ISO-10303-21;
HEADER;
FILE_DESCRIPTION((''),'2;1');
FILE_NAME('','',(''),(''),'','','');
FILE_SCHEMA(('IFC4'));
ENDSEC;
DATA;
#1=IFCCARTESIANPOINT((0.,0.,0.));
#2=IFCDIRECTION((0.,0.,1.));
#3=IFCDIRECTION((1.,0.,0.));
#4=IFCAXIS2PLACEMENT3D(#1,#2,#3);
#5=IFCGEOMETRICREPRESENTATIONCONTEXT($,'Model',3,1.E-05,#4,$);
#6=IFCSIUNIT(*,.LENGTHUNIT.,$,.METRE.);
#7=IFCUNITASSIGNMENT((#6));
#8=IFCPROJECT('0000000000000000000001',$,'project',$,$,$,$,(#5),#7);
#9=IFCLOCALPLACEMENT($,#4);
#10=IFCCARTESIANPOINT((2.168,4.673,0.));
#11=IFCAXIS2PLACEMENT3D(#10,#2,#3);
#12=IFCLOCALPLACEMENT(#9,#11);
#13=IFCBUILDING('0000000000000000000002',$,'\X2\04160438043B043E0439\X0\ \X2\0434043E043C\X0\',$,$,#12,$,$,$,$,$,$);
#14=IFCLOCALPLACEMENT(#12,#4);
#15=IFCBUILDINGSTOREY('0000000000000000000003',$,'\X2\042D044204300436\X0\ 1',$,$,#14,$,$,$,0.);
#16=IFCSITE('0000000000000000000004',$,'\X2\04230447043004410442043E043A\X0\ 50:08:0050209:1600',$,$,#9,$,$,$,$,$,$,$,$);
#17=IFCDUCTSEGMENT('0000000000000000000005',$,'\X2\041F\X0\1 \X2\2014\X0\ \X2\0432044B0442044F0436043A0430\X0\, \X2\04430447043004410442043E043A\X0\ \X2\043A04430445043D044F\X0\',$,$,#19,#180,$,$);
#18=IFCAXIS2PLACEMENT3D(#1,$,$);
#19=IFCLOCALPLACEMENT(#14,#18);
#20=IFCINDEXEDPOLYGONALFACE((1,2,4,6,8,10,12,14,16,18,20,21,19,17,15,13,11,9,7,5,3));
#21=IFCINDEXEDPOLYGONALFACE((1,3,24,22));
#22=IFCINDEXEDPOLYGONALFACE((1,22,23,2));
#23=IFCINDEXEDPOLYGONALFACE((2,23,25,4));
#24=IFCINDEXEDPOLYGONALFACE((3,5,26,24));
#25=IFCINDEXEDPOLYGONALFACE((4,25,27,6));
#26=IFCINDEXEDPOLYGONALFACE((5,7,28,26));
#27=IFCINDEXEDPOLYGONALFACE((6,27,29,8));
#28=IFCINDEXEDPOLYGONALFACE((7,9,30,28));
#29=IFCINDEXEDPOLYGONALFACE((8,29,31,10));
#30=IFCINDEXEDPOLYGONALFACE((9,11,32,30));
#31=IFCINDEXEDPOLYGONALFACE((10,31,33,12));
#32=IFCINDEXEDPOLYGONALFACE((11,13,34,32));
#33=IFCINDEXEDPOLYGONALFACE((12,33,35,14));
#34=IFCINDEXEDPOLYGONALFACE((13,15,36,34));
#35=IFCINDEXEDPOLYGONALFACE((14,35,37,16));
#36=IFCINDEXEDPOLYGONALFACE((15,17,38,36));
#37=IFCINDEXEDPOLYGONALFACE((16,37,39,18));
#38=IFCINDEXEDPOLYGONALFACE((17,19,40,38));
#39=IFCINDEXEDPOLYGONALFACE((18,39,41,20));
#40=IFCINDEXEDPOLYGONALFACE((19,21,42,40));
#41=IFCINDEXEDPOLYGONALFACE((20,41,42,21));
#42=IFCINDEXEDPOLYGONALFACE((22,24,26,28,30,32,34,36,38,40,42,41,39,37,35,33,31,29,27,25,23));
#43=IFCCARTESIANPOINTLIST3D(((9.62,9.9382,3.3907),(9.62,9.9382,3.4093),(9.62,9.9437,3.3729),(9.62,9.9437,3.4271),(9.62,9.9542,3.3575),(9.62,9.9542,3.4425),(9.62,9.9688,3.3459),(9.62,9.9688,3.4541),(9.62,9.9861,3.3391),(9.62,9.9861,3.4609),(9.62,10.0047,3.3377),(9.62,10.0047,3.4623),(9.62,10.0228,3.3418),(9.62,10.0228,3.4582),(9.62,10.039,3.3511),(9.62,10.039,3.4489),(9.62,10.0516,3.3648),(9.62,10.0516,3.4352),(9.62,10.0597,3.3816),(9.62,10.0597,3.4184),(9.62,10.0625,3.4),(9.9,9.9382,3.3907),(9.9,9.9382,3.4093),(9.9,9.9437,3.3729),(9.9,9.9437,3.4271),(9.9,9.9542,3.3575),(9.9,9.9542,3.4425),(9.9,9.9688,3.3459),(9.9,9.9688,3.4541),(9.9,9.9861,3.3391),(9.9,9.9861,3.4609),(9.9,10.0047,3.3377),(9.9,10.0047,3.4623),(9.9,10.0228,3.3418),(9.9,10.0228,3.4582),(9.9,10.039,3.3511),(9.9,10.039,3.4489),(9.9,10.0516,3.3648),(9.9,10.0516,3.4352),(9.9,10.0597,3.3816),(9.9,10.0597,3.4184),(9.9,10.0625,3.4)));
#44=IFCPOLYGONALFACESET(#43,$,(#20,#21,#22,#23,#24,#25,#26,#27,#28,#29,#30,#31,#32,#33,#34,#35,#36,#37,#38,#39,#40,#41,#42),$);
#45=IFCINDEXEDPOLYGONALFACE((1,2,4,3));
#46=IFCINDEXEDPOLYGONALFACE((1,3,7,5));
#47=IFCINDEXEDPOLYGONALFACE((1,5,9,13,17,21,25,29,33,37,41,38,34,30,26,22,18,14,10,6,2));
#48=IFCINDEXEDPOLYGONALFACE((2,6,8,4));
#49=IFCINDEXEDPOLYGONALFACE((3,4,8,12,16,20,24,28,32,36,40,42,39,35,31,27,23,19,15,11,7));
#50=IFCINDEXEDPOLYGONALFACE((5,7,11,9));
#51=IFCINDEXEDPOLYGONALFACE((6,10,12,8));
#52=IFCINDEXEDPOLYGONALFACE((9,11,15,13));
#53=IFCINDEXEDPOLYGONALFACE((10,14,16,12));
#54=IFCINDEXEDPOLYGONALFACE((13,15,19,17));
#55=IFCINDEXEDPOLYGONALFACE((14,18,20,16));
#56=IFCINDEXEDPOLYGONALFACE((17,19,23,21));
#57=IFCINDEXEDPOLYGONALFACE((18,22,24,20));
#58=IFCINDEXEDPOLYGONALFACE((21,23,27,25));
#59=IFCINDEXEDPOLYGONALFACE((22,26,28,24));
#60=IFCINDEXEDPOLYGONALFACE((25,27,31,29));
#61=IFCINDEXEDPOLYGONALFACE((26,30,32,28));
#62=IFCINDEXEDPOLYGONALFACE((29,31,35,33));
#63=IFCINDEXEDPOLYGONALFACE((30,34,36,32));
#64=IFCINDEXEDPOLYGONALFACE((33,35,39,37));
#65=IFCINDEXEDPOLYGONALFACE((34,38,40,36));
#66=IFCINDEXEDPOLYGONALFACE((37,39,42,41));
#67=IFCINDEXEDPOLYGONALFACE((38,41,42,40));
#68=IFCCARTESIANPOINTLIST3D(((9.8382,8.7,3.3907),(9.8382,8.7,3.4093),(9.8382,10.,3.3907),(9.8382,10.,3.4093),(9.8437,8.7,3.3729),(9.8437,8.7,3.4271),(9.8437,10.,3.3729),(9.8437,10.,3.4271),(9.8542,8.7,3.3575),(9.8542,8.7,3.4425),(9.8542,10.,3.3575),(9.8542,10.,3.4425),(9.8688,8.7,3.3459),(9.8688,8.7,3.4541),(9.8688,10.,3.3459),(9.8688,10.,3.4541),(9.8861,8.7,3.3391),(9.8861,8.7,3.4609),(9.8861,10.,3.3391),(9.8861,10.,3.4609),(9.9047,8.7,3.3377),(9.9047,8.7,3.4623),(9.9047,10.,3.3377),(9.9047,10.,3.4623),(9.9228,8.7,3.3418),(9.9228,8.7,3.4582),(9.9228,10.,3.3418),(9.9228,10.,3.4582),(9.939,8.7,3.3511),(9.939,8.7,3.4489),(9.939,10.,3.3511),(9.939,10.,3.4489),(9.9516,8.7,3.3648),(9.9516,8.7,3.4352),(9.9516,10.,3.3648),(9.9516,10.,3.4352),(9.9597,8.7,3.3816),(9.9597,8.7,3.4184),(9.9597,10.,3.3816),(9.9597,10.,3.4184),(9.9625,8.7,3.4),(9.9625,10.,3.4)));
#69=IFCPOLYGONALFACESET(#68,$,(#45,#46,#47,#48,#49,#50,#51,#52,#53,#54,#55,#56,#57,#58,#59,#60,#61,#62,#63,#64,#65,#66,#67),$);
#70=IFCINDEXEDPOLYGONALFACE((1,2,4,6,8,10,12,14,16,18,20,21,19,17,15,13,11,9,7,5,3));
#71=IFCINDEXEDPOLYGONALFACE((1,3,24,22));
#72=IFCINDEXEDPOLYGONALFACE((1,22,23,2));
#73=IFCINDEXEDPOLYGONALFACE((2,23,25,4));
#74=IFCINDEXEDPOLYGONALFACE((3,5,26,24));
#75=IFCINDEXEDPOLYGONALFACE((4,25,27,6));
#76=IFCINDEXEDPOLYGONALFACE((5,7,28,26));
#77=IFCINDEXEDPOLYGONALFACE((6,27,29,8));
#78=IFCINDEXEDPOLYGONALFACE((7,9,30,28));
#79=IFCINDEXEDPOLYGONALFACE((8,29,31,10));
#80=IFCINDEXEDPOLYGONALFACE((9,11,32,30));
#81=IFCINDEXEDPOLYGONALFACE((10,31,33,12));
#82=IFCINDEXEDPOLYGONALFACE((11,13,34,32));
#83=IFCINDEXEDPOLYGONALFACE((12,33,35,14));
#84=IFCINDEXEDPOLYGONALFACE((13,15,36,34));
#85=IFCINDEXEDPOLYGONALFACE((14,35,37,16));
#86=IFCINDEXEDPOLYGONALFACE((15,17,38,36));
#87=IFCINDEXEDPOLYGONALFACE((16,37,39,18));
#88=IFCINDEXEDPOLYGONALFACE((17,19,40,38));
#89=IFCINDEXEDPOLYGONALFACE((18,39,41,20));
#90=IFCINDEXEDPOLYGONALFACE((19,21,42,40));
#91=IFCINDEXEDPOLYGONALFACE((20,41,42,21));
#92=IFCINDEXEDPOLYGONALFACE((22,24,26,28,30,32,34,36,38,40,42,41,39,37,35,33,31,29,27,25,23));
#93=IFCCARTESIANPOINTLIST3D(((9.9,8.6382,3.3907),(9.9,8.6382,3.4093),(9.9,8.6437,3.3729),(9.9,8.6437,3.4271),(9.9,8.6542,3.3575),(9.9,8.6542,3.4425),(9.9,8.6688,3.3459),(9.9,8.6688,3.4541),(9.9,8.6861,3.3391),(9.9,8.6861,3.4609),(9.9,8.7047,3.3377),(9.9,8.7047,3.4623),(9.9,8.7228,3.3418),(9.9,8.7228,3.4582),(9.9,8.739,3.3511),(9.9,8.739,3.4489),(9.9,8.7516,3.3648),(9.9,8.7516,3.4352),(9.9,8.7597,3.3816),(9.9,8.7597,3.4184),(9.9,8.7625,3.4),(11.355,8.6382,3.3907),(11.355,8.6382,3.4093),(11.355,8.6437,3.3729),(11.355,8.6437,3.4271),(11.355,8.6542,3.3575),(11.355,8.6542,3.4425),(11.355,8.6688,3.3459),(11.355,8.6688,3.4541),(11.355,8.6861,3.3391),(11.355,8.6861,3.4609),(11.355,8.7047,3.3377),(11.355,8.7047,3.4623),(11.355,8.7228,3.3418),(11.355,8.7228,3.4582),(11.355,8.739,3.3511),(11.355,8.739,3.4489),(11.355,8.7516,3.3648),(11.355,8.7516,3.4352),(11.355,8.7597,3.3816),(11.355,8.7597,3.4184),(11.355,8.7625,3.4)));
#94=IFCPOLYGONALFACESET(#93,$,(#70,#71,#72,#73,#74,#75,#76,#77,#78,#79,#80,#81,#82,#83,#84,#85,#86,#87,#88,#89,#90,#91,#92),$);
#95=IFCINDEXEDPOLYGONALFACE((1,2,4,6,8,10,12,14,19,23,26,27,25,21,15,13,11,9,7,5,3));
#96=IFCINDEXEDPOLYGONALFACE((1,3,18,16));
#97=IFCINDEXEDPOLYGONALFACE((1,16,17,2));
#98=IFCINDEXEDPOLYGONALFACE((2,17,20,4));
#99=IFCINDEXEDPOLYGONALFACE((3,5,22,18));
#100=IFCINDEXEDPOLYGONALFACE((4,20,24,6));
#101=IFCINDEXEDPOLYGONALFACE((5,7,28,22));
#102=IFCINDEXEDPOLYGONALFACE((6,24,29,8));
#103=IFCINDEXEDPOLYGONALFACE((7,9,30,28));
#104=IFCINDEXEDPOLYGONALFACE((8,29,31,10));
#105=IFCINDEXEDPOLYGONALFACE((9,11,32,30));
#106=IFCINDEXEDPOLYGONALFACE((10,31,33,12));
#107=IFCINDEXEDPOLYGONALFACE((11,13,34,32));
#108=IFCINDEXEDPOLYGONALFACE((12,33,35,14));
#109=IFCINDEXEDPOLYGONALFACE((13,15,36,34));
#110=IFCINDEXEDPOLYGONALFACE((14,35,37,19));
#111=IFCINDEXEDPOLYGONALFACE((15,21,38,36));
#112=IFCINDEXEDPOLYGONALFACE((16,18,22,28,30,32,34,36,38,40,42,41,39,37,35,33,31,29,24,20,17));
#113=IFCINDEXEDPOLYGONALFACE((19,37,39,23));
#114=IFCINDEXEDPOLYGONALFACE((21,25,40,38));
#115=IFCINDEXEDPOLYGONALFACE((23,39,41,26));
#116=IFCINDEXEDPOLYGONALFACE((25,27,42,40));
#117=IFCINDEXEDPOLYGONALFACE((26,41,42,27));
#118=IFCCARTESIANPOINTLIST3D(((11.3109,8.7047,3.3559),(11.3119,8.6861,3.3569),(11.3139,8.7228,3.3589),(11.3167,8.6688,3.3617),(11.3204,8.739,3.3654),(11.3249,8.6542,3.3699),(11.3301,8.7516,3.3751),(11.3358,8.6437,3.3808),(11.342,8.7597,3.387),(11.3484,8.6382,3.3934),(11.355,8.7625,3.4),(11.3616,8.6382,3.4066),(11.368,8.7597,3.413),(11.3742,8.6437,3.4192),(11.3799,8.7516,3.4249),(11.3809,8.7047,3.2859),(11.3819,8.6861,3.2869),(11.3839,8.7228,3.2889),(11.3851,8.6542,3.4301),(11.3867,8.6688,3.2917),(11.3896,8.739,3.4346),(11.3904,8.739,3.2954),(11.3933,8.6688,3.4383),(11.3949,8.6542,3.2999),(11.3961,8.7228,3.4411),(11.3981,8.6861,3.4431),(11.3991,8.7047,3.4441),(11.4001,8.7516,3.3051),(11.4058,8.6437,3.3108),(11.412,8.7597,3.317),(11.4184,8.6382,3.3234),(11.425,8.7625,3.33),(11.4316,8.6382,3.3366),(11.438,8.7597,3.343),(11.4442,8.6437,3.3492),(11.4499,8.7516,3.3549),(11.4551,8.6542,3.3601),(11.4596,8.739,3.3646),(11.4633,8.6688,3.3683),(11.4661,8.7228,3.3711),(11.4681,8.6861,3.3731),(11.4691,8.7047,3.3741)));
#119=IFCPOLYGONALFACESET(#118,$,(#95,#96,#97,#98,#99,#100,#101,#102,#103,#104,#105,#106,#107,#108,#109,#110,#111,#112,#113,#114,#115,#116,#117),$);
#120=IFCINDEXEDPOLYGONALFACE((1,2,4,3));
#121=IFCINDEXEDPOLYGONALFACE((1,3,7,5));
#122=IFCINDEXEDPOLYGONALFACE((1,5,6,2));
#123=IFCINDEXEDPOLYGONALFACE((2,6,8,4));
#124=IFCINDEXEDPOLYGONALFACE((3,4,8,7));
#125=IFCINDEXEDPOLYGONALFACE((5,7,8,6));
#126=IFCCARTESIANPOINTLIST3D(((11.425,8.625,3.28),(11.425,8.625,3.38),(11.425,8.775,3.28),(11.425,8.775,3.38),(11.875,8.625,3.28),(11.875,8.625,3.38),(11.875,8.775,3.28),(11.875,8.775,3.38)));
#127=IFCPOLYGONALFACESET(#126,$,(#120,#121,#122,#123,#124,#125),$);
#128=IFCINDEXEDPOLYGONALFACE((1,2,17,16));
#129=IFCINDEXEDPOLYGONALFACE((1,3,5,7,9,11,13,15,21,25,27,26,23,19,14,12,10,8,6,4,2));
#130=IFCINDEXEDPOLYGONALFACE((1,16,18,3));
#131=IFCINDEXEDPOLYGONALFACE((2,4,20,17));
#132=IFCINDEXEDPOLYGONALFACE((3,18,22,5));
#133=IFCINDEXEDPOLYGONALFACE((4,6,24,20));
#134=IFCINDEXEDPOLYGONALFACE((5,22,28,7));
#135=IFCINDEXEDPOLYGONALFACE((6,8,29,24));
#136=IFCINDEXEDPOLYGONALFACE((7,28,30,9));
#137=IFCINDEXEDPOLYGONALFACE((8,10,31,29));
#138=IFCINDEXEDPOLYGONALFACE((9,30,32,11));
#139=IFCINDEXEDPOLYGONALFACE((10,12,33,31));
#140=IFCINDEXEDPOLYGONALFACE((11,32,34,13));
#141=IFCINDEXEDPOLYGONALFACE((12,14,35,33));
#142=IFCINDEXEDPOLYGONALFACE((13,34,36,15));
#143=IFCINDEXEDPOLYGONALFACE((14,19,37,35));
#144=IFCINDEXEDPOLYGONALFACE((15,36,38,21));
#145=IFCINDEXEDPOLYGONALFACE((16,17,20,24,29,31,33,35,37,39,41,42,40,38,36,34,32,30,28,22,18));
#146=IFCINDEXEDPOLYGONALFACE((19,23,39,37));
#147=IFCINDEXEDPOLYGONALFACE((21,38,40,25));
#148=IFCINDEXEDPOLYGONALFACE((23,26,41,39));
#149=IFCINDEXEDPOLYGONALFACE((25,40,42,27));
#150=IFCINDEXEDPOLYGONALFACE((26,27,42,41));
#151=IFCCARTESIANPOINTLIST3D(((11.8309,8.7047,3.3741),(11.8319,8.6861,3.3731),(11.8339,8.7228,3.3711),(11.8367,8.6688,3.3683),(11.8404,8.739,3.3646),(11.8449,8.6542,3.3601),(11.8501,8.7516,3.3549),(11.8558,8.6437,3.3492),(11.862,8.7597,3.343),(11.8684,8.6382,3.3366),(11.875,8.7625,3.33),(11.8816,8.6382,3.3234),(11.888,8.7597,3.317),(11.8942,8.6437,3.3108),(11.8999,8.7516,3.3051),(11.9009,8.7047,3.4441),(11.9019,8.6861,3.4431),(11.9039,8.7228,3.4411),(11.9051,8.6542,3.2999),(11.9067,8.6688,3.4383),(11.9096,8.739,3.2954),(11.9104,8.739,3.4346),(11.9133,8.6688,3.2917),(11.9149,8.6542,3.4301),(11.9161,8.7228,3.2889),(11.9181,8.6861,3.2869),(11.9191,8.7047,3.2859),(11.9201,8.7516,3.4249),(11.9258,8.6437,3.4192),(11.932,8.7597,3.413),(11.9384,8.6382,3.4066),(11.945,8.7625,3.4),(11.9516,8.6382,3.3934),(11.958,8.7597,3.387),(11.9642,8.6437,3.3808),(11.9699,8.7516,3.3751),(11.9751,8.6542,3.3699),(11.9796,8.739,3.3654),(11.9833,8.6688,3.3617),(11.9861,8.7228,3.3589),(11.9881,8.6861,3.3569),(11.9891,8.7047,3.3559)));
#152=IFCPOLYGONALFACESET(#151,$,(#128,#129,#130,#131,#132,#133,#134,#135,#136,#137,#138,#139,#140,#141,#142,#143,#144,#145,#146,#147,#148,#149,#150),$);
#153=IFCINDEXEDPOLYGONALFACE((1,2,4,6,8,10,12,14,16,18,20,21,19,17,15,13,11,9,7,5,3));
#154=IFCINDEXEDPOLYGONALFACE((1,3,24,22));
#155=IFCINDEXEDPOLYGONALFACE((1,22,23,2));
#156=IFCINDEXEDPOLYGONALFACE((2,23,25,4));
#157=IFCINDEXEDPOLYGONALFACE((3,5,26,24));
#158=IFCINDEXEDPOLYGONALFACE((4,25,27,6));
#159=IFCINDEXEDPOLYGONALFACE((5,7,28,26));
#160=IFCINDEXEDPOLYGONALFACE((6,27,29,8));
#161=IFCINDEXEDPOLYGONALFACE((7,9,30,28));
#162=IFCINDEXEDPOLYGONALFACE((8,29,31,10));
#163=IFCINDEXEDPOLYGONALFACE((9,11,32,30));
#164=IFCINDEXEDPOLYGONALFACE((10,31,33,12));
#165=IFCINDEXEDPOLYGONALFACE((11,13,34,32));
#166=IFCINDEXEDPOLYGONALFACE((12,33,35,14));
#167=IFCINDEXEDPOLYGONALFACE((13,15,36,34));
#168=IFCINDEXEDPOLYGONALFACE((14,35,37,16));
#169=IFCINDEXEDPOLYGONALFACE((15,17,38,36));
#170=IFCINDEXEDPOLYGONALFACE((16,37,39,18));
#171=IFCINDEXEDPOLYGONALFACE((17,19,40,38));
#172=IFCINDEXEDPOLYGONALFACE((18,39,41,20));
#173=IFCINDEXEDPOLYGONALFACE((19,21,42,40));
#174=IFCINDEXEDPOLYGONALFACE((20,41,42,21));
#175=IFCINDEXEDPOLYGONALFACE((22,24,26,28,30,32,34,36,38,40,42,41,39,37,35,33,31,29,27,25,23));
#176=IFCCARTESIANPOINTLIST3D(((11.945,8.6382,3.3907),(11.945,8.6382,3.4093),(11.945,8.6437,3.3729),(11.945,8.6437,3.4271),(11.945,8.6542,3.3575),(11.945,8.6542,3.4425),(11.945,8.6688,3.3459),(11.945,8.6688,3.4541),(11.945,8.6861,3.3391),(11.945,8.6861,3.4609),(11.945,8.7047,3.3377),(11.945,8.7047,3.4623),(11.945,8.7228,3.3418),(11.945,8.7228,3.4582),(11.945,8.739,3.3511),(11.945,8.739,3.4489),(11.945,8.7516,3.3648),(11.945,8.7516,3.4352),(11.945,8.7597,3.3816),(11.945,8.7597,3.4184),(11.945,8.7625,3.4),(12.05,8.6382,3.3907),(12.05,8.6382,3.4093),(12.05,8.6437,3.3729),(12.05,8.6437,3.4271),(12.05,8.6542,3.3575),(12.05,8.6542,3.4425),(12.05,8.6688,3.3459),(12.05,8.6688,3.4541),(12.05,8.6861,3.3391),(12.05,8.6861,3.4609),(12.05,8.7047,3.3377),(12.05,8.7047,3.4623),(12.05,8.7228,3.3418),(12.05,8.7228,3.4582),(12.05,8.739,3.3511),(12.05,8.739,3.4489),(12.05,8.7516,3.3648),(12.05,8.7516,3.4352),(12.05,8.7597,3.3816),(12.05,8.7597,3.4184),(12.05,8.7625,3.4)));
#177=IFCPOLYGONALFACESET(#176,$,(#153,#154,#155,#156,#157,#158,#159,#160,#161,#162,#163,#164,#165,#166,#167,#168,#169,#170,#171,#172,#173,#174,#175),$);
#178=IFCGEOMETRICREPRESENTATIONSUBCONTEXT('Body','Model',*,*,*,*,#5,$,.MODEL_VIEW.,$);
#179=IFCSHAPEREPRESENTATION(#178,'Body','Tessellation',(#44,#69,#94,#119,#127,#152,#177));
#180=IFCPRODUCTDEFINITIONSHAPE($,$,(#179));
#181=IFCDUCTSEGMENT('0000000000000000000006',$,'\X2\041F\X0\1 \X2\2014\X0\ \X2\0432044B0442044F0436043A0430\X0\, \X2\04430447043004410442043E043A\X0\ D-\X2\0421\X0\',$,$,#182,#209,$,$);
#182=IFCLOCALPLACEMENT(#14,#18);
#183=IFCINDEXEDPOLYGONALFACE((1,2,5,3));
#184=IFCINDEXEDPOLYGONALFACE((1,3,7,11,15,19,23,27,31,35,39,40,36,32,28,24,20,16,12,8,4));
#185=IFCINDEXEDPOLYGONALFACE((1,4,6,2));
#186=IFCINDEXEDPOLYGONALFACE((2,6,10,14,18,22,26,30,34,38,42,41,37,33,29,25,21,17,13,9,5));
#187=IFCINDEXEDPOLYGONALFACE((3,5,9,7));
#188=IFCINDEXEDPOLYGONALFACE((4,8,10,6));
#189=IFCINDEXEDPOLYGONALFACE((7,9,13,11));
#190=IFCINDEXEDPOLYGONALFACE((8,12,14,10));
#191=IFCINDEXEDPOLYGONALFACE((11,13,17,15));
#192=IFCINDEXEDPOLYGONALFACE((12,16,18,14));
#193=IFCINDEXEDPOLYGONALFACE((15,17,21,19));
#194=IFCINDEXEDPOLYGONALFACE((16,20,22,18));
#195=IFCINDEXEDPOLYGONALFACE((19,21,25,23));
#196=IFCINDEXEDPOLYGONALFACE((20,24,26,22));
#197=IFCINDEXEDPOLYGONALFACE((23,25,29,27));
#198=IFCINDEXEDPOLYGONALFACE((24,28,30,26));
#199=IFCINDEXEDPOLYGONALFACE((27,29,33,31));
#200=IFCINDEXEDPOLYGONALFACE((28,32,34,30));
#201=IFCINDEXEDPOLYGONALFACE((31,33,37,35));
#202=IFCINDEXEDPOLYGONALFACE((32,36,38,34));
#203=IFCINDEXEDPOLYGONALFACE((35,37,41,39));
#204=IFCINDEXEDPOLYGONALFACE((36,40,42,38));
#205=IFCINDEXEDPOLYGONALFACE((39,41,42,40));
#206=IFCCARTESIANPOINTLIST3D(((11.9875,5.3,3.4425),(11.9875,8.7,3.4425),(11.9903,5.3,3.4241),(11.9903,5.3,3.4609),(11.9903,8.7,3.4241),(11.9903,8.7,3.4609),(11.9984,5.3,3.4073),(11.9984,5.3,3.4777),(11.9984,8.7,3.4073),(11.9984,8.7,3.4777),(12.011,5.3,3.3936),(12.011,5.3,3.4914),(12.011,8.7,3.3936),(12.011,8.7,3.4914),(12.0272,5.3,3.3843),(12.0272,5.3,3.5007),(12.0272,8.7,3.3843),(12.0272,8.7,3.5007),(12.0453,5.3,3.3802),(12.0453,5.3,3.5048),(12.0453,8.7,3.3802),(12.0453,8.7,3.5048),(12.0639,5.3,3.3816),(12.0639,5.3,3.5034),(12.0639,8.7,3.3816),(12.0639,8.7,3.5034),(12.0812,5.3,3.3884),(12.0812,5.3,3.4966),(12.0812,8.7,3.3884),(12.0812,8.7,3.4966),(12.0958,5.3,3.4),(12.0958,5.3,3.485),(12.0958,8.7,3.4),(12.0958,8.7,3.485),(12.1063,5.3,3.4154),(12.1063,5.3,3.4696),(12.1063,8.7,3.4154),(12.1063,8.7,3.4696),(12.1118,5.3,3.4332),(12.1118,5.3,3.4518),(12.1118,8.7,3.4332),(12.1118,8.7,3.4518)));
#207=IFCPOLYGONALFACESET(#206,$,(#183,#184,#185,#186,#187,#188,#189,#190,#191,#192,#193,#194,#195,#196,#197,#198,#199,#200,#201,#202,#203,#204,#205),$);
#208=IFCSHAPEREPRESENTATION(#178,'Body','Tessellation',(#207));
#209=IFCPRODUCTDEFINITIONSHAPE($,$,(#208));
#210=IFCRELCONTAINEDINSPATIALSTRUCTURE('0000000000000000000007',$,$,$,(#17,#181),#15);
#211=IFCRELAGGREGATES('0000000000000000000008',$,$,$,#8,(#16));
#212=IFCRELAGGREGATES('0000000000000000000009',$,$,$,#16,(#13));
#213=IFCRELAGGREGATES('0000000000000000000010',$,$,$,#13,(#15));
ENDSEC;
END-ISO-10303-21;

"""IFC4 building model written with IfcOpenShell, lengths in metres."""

from ifc_helpers import new_model, si_unit, frame, origin_with_axes, origin_2d, place, context, subcontext, project, spatial, rectangle, circle, extrude, element, save


model = new_model("IFC4")

# Units and contexts
model_context = context("Model", 3, precision=1e-05, world=origin_with_axes())
body_context = subcontext(model_context, "Body", "Model", "MODEL_VIEW")
ifc_project = project(units=[si_unit("LENGTHUNIT", "METRE")], contexts=[model_context])

# Site, building, storey
site_placement = place(None, origin_with_axes())
site = spatial("IfcSite", under=ifc_project, at=site_placement, Name="Участок 50:08:0050209:1600")
building_placement = place(site_placement, frame((2.168, 4.673, 0.0), z_axis=(0.0, 0.0, 1.0), x_axis=(1.0, 0.0, 0.0)))
building = spatial("IfcBuilding", under=site, at=building_placement, Name="Жилой дом")
storey_placement = place(building_placement, origin_with_axes())
storey = spatial("IfcBuildingStorey", under=building, at=storey_placement, Name="Этаж 1", Elevation=0.0)

# Duct segments
duct_segment_1_placement = place(storey_placement, origin_with_axes())
element("IfcDuctSegment", 1, at=duct_segment_1_placement, inside=storey, Name="П1 — вытяжка, участок кухня", context=body_context, shape_type="SweptSolid", body=[
    extrude(circle(Radius=0.0625, at=origin_2d()), frame((9.62, 10.0, 3.4), z_axis=(1.0, 0.0, 0.0), x_axis=(0.0, 1.0, 0.0)), (0.0, 0.0, 1.0), 0.28),
    extrude(circle(Radius=0.0625, at=origin_2d()), frame((9.9, 10.0, 3.4), z_axis=(0.0, -1.0, 0.0), x_axis=(1.0, 0.0, 0.0)), (0.0, 0.0, 1.0), 1.3),
    extrude(circle(Radius=0.0625, at=origin_2d()), frame((9.9, 8.7, 3.4), z_axis=(1.0, 0.0, 0.0), x_axis=(0.0, 1.0, 0.0)), (0.0, 0.0, 1.0), 1.455),
    extrude(circle(Radius=0.0625, at=origin_2d()), frame((11.355, 8.7, 3.4), z_axis=(0.707107, 0.0, -0.707107), x_axis=(0.0, 1.0, 0.0)), (0.0, 0.0, 1.0), 0.099),
    extrude(rectangle(XDim=0.15, YDim=0.1, at=origin_2d()), frame((11.425, 8.7, 3.33), z_axis=(1.0, 0.0, 0.0), x_axis=(0.0, 1.0, 0.0)), (0.0, 0.0, 1.0), 0.45),
    extrude(circle(Radius=0.0625, at=origin_2d()), frame((11.875, 8.7, 3.33), z_axis=(0.707107, 0.0, 0.707107), x_axis=(0.0, 1.0, 0.0)), (0.0, 0.0, 1.0), 0.099),
    extrude(circle(Radius=0.0625, at=origin_2d()), frame((11.945, 8.7, 3.4), z_axis=(1.0, 0.0, 0.0), x_axis=(0.0, 1.0, 0.0)), (0.0, 0.0, 1.0), 0.105),
])
duct_segment_2_placement = place(storey_placement, origin_with_axes())
element("IfcDuctSegment", 2, at=duct_segment_2_placement, inside=storey, Name="П1 — вытяжка, участок D-С", context=body_context, shape_type="SweptSolid", body=[
    extrude(circle(Radius=0.0625, at=origin_2d()), frame((12.05, 5.3, 3.4425), z_axis=(0.0, 1.0, 0.0), x_axis=(-1.0, 0.0, 0.0)), (0.0, 0.0, 1.0), 3.4),
])

save(model, "model.ifc")
